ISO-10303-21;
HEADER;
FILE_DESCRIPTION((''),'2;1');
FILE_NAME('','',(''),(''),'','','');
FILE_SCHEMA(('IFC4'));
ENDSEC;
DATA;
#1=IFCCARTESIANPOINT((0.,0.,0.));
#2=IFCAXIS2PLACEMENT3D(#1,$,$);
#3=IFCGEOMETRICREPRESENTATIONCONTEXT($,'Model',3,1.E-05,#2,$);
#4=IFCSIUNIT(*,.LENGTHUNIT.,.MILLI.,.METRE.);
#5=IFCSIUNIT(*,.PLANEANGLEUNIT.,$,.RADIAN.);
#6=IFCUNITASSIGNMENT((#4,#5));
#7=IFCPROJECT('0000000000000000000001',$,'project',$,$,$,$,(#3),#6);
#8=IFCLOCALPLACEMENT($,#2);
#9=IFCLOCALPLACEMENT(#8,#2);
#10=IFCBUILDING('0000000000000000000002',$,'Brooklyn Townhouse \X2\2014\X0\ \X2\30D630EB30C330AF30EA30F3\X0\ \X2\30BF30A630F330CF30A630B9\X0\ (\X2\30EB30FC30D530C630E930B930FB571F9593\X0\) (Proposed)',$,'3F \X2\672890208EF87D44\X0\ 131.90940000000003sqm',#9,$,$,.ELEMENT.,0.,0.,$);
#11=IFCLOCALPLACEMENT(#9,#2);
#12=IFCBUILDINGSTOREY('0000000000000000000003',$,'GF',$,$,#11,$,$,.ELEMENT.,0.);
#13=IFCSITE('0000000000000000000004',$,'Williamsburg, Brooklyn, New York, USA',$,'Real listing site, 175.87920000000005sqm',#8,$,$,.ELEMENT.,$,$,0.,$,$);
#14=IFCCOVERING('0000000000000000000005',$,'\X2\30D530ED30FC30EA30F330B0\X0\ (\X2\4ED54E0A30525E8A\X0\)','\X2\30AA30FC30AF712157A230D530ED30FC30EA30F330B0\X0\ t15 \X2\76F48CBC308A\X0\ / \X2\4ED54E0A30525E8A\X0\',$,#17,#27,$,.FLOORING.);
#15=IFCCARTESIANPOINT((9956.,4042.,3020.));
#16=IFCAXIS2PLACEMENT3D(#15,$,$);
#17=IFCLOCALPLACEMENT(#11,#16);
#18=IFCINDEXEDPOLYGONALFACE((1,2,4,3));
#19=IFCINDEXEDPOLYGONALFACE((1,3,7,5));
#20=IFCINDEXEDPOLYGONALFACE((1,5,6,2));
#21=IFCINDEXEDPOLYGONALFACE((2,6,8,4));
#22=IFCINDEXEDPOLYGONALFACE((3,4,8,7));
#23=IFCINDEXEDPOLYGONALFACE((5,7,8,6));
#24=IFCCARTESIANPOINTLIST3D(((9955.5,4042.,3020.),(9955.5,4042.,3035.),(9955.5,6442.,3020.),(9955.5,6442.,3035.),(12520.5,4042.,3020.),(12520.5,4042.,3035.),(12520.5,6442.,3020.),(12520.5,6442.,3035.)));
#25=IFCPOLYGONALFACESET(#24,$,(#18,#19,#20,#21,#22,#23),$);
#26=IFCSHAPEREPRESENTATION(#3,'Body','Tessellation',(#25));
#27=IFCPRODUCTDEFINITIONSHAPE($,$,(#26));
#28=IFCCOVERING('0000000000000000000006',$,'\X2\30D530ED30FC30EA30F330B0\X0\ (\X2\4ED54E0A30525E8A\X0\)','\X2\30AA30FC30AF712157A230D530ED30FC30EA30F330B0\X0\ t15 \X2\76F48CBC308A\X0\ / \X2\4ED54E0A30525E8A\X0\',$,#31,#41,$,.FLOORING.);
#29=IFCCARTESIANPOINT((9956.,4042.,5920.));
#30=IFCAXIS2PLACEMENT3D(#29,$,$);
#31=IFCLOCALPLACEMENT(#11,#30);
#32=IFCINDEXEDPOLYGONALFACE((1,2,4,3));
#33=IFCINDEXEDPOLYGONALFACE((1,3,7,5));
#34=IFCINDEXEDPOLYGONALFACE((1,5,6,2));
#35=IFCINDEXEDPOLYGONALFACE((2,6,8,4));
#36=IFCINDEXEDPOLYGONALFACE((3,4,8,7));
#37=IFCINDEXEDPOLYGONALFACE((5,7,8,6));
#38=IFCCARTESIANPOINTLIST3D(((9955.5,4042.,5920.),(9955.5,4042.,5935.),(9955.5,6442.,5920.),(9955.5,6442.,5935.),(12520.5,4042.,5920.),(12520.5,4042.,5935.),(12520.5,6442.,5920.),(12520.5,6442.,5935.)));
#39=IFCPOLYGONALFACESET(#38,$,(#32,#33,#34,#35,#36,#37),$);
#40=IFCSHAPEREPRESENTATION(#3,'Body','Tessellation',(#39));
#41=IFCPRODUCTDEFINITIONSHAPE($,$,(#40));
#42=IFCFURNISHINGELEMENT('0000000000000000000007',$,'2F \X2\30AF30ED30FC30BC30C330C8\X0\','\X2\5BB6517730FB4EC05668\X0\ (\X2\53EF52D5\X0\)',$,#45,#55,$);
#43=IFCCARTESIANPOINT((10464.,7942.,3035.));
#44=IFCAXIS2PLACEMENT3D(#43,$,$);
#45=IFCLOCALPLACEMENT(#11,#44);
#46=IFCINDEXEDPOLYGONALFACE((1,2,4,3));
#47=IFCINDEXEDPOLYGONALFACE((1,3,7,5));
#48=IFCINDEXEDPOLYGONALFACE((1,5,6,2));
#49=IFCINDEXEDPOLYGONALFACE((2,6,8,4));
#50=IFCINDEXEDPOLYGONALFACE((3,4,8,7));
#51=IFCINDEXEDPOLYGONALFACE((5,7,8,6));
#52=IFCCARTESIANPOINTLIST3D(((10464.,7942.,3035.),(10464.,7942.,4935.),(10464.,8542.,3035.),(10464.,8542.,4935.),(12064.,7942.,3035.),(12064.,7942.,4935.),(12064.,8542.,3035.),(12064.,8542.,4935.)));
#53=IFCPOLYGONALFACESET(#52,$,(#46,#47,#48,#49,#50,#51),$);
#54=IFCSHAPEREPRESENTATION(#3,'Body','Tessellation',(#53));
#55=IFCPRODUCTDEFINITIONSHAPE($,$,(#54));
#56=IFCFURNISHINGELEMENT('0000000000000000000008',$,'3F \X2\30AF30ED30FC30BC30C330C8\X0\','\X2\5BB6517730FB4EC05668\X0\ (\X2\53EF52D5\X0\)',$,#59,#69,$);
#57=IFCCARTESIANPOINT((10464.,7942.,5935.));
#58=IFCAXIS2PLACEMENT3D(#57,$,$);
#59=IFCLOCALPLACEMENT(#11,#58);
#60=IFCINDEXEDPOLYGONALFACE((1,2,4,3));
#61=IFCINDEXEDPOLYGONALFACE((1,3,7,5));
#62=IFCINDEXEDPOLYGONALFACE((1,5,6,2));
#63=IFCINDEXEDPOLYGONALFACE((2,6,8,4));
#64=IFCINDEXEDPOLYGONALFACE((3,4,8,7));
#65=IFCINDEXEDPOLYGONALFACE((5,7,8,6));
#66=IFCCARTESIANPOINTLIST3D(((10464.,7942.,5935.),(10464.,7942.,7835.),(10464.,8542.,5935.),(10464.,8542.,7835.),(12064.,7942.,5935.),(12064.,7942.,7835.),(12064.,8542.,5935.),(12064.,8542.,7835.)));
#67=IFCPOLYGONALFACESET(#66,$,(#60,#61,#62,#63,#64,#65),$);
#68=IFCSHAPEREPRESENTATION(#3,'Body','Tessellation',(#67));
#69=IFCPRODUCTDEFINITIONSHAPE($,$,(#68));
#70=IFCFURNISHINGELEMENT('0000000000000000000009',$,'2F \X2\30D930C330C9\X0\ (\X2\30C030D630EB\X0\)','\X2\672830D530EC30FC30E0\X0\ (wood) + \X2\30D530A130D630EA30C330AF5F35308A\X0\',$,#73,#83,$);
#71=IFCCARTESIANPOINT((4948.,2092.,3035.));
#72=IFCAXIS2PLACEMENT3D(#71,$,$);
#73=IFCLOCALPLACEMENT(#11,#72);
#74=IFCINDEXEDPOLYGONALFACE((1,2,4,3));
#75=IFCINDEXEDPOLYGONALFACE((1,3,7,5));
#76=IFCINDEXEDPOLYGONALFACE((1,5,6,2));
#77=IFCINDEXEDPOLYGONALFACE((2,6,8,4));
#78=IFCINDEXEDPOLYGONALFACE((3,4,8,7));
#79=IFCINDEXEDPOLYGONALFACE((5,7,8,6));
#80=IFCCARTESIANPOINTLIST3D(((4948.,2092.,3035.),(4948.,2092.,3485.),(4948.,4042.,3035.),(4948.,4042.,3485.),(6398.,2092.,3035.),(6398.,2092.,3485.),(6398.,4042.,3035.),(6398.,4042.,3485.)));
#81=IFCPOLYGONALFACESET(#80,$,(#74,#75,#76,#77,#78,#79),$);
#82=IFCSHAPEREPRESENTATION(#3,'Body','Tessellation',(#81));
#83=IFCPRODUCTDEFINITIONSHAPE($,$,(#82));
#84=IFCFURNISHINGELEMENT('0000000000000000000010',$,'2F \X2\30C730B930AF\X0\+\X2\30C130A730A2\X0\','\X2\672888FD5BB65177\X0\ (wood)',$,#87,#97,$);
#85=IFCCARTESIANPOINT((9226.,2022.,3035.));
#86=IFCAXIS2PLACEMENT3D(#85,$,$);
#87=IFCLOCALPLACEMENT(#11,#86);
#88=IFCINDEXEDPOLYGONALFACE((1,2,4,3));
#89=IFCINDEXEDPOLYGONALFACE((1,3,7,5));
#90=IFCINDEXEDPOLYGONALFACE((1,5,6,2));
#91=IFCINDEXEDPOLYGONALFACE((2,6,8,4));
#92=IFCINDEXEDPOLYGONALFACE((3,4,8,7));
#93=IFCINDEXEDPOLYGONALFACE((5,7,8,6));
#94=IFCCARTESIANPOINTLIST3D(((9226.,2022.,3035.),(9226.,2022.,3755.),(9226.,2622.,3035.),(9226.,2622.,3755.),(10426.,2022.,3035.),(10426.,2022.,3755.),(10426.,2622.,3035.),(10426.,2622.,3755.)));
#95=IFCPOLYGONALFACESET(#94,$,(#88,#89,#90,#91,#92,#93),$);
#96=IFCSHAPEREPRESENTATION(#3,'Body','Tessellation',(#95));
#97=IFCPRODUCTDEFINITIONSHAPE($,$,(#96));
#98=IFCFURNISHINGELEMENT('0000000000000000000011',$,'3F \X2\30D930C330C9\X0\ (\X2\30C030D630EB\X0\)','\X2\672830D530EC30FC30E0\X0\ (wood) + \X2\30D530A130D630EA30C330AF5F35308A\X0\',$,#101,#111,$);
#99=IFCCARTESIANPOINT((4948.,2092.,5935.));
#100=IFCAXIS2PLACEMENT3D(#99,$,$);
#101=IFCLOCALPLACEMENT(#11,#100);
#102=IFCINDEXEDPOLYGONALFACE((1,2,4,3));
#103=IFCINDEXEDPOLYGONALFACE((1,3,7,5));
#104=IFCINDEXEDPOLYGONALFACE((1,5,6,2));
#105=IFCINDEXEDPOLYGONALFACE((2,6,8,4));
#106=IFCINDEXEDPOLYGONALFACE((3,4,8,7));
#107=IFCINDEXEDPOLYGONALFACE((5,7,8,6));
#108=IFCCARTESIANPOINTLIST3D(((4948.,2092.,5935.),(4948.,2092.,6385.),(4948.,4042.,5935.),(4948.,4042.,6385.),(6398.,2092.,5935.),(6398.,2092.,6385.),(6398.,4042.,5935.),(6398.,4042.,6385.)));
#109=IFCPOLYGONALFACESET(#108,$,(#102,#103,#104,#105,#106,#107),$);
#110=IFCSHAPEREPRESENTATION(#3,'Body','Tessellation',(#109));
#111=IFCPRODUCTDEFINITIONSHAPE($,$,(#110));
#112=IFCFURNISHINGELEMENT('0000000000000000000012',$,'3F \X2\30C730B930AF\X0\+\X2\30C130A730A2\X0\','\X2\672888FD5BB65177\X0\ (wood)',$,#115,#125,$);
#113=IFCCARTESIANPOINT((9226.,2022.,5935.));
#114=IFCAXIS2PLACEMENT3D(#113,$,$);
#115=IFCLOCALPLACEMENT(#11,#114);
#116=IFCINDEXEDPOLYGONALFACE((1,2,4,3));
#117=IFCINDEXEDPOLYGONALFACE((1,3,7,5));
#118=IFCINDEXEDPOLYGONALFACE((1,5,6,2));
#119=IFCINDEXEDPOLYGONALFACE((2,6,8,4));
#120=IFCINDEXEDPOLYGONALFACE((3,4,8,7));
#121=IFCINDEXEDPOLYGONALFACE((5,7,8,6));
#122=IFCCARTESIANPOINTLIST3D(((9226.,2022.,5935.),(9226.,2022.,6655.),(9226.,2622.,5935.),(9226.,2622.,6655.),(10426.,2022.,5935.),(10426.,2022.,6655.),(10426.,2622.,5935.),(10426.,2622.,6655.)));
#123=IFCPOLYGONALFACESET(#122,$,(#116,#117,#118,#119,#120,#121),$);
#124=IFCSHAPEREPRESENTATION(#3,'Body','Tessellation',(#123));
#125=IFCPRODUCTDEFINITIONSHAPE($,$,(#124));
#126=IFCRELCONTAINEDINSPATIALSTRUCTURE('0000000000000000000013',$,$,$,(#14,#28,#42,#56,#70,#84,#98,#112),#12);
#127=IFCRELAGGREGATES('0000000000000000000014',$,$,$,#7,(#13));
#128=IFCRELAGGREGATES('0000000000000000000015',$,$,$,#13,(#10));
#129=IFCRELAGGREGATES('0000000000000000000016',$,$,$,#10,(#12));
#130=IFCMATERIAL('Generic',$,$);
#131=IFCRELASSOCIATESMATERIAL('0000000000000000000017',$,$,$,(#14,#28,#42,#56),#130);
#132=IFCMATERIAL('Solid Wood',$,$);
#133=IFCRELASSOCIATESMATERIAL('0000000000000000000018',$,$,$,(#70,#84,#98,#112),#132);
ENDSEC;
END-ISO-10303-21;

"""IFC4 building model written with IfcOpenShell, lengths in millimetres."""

from ifc_helpers import new_model, si_unit, frame, frame_2d, origin, place, context, project, spatial, rectangle, extrude, material, element, save


model = new_model("IFC4")

# Units and contexts
model_context = context("Model", 3, precision=1e-05, world=origin())
ifc_project = project(units=[si_unit("LENGTHUNIT", "METRE", prefix="MILLI"), si_unit("PLANEANGLEUNIT", "RADIAN")], contexts=[model_context])

# Site, building, storey
site_placement = place(None, origin())
site = spatial("IfcSite", under=ifc_project, at=site_placement, Name="Williamsburg, Brooklyn, New York, USA", ObjectType="Real listing site, 175.87920000000005sqm", CompositionType="ELEMENT", RefElevation=0.0)
building_placement = place(site_placement, origin())
building = spatial("IfcBuilding", under=site, at=building_placement, Name="Brooklyn Townhouse — ブルックリン タウンハウス (ルーフテラス・土間) (Proposed)", ObjectType="3F 木造軸組 131.90940000000003sqm", CompositionType="ELEMENT", ElevationOfRefHeight=0.0, ElevationOfTerrain=0.0)
storey_placement = place(building_placement, origin())
storey = spatial("IfcBuildingStorey", under=building, at=storey_placement, Name="GF", CompositionType="ELEMENT", Elevation=0.0)

# Shared definitions
ifc_material_1 = material(Name="Solid Wood")

# Coverings
ifc_material_2 = material(Name="Generic")
covering_1_placement = place(storey_placement, frame((9956.0, 4042.0, 3020.0)))
element("IfcCovering", 1, at=covering_1_placement, inside=storey, material=ifc_material_2, Name="フローリング (仕上げ床)", Description="オーク無垢フローリング t15 直貼り / 仕上げ床", PredefinedType="FLOORING", context=model_context, shape_type="SweptSolid", body=[
    extrude(rectangle(XDim=2565.0, YDim=2400.0, at=frame_2d((1282.0, 1200.0))), frame((9956.0, 4042.0, 3020.0)), (0.0, 0.0, 1.0), 15.0),
])
covering_2_placement = place(storey_placement, frame((9956.0, 4042.0, 5920.0)))
element("IfcCovering", 2, at=covering_2_placement, inside=storey, material=ifc_material_2, Name="フローリング (仕上げ床)", Description="オーク無垢フローリング t15 直貼り / 仕上げ床", PredefinedType="FLOORING", context=model_context, shape_type="SweptSolid", body=[
    extrude(rectangle(XDim=2565.0, YDim=2400.0, at=frame_2d((1282.0, 1200.0))), frame((9956.0, 4042.0, 5920.0)), (0.0, 0.0, 1.0), 15.0),
])

# Furnishing elements
furnishing_1_placement = place(storey_placement, frame((10464.0, 7942.0, 3035.0)))
element("IfcFurnishingElement", 3, at=furnishing_1_placement, inside=storey, material=ifc_material_2, Name="2F クローゼット", Description="家具・什器 (可動)", context=model_context, shape_type="SweptSolid", body=[
    extrude(rectangle(XDim=1600.0, YDim=600.0, at=frame_2d((800.0, 300.0))), frame((10464.0, 7942.0, 3035.0)), (0.0, 0.0, 1.0), 1900.0),
])
furnishing_2_placement = place(storey_placement, frame((10464.0, 7942.0, 5935.0)))
element("IfcFurnishingElement", 4, at=furnishing_2_placement, inside=storey, material=ifc_material_2, Name="3F クローゼット", Description="家具・什器 (可動)", context=model_context, shape_type="SweptSolid", body=[
    extrude(rectangle(XDim=1600.0, YDim=600.0, at=frame_2d((800.0, 300.0))), frame((10464.0, 7942.0, 5935.0)), (0.0, 0.0, 1.0), 1900.0),
])
furnishing_3_placement = place(storey_placement, frame((4948.0, 2092.0, 3035.0)))
element("IfcFurnishingElement", 5, at=furnishing_3_placement, inside=storey, material=ifc_material_1, Name="2F ベッド (ダブル)", Description="木フレーム (wood) + ファブリック張り", context=model_context, shape_type="SweptSolid", body=[
    extrude(rectangle(XDim=1450.0, YDim=1950.0, at=frame_2d((725.0, 975.0))), frame((4948.0, 2092.0, 3035.0)), (0.0, 0.0, 1.0), 450.0),
])
furnishing_4_placement = place(storey_placement, frame((9226.0, 2022.0, 3035.0)))
element("IfcFurnishingElement", 6, at=furnishing_4_placement, inside=storey, material=ifc_material_1, Name="2F デスク+チェア", Description="木製家具 (wood)", context=model_context, shape_type="SweptSolid", body=[
    extrude(rectangle(XDim=1200.0, YDim=600.0, at=frame_2d((600.0, 300.0))), frame((9226.0, 2022.0, 3035.0)), (0.0, 0.0, 1.0), 720.0),
])
furnishing_5_placement = place(storey_placement, frame((4948.0, 2092.0, 5935.0)))
element("IfcFurnishingElement", 7, at=furnishing_5_placement, inside=storey, material=ifc_material_1, Name="3F ベッド (ダブル)", Description="木フレーム (wood) + ファブリック張り", context=model_context, shape_type="SweptSolid", body=[
    extrude(rectangle(XDim=1450.0, YDim=1950.0, at=frame_2d((725.0, 975.0))), frame((4948.0, 2092.0, 5935.0)), (0.0, 0.0, 1.0), 450.0),
])
furnishing_6_placement = place(storey_placement, frame((9226.0, 2022.0, 5935.0)))
element("IfcFurnishingElement", 8, at=furnishing_6_placement, inside=storey, material=ifc_material_1, Name="3F デスク+チェア", Description="木製家具 (wood)", context=model_context, shape_type="SweptSolid", body=[
    extrude(rectangle(XDim=1200.0, YDim=600.0, at=frame_2d((600.0, 300.0))), frame((9226.0, 2022.0, 5935.0)), (0.0, 0.0, 1.0), 720.0),
])

save(model, "model.ifc")
